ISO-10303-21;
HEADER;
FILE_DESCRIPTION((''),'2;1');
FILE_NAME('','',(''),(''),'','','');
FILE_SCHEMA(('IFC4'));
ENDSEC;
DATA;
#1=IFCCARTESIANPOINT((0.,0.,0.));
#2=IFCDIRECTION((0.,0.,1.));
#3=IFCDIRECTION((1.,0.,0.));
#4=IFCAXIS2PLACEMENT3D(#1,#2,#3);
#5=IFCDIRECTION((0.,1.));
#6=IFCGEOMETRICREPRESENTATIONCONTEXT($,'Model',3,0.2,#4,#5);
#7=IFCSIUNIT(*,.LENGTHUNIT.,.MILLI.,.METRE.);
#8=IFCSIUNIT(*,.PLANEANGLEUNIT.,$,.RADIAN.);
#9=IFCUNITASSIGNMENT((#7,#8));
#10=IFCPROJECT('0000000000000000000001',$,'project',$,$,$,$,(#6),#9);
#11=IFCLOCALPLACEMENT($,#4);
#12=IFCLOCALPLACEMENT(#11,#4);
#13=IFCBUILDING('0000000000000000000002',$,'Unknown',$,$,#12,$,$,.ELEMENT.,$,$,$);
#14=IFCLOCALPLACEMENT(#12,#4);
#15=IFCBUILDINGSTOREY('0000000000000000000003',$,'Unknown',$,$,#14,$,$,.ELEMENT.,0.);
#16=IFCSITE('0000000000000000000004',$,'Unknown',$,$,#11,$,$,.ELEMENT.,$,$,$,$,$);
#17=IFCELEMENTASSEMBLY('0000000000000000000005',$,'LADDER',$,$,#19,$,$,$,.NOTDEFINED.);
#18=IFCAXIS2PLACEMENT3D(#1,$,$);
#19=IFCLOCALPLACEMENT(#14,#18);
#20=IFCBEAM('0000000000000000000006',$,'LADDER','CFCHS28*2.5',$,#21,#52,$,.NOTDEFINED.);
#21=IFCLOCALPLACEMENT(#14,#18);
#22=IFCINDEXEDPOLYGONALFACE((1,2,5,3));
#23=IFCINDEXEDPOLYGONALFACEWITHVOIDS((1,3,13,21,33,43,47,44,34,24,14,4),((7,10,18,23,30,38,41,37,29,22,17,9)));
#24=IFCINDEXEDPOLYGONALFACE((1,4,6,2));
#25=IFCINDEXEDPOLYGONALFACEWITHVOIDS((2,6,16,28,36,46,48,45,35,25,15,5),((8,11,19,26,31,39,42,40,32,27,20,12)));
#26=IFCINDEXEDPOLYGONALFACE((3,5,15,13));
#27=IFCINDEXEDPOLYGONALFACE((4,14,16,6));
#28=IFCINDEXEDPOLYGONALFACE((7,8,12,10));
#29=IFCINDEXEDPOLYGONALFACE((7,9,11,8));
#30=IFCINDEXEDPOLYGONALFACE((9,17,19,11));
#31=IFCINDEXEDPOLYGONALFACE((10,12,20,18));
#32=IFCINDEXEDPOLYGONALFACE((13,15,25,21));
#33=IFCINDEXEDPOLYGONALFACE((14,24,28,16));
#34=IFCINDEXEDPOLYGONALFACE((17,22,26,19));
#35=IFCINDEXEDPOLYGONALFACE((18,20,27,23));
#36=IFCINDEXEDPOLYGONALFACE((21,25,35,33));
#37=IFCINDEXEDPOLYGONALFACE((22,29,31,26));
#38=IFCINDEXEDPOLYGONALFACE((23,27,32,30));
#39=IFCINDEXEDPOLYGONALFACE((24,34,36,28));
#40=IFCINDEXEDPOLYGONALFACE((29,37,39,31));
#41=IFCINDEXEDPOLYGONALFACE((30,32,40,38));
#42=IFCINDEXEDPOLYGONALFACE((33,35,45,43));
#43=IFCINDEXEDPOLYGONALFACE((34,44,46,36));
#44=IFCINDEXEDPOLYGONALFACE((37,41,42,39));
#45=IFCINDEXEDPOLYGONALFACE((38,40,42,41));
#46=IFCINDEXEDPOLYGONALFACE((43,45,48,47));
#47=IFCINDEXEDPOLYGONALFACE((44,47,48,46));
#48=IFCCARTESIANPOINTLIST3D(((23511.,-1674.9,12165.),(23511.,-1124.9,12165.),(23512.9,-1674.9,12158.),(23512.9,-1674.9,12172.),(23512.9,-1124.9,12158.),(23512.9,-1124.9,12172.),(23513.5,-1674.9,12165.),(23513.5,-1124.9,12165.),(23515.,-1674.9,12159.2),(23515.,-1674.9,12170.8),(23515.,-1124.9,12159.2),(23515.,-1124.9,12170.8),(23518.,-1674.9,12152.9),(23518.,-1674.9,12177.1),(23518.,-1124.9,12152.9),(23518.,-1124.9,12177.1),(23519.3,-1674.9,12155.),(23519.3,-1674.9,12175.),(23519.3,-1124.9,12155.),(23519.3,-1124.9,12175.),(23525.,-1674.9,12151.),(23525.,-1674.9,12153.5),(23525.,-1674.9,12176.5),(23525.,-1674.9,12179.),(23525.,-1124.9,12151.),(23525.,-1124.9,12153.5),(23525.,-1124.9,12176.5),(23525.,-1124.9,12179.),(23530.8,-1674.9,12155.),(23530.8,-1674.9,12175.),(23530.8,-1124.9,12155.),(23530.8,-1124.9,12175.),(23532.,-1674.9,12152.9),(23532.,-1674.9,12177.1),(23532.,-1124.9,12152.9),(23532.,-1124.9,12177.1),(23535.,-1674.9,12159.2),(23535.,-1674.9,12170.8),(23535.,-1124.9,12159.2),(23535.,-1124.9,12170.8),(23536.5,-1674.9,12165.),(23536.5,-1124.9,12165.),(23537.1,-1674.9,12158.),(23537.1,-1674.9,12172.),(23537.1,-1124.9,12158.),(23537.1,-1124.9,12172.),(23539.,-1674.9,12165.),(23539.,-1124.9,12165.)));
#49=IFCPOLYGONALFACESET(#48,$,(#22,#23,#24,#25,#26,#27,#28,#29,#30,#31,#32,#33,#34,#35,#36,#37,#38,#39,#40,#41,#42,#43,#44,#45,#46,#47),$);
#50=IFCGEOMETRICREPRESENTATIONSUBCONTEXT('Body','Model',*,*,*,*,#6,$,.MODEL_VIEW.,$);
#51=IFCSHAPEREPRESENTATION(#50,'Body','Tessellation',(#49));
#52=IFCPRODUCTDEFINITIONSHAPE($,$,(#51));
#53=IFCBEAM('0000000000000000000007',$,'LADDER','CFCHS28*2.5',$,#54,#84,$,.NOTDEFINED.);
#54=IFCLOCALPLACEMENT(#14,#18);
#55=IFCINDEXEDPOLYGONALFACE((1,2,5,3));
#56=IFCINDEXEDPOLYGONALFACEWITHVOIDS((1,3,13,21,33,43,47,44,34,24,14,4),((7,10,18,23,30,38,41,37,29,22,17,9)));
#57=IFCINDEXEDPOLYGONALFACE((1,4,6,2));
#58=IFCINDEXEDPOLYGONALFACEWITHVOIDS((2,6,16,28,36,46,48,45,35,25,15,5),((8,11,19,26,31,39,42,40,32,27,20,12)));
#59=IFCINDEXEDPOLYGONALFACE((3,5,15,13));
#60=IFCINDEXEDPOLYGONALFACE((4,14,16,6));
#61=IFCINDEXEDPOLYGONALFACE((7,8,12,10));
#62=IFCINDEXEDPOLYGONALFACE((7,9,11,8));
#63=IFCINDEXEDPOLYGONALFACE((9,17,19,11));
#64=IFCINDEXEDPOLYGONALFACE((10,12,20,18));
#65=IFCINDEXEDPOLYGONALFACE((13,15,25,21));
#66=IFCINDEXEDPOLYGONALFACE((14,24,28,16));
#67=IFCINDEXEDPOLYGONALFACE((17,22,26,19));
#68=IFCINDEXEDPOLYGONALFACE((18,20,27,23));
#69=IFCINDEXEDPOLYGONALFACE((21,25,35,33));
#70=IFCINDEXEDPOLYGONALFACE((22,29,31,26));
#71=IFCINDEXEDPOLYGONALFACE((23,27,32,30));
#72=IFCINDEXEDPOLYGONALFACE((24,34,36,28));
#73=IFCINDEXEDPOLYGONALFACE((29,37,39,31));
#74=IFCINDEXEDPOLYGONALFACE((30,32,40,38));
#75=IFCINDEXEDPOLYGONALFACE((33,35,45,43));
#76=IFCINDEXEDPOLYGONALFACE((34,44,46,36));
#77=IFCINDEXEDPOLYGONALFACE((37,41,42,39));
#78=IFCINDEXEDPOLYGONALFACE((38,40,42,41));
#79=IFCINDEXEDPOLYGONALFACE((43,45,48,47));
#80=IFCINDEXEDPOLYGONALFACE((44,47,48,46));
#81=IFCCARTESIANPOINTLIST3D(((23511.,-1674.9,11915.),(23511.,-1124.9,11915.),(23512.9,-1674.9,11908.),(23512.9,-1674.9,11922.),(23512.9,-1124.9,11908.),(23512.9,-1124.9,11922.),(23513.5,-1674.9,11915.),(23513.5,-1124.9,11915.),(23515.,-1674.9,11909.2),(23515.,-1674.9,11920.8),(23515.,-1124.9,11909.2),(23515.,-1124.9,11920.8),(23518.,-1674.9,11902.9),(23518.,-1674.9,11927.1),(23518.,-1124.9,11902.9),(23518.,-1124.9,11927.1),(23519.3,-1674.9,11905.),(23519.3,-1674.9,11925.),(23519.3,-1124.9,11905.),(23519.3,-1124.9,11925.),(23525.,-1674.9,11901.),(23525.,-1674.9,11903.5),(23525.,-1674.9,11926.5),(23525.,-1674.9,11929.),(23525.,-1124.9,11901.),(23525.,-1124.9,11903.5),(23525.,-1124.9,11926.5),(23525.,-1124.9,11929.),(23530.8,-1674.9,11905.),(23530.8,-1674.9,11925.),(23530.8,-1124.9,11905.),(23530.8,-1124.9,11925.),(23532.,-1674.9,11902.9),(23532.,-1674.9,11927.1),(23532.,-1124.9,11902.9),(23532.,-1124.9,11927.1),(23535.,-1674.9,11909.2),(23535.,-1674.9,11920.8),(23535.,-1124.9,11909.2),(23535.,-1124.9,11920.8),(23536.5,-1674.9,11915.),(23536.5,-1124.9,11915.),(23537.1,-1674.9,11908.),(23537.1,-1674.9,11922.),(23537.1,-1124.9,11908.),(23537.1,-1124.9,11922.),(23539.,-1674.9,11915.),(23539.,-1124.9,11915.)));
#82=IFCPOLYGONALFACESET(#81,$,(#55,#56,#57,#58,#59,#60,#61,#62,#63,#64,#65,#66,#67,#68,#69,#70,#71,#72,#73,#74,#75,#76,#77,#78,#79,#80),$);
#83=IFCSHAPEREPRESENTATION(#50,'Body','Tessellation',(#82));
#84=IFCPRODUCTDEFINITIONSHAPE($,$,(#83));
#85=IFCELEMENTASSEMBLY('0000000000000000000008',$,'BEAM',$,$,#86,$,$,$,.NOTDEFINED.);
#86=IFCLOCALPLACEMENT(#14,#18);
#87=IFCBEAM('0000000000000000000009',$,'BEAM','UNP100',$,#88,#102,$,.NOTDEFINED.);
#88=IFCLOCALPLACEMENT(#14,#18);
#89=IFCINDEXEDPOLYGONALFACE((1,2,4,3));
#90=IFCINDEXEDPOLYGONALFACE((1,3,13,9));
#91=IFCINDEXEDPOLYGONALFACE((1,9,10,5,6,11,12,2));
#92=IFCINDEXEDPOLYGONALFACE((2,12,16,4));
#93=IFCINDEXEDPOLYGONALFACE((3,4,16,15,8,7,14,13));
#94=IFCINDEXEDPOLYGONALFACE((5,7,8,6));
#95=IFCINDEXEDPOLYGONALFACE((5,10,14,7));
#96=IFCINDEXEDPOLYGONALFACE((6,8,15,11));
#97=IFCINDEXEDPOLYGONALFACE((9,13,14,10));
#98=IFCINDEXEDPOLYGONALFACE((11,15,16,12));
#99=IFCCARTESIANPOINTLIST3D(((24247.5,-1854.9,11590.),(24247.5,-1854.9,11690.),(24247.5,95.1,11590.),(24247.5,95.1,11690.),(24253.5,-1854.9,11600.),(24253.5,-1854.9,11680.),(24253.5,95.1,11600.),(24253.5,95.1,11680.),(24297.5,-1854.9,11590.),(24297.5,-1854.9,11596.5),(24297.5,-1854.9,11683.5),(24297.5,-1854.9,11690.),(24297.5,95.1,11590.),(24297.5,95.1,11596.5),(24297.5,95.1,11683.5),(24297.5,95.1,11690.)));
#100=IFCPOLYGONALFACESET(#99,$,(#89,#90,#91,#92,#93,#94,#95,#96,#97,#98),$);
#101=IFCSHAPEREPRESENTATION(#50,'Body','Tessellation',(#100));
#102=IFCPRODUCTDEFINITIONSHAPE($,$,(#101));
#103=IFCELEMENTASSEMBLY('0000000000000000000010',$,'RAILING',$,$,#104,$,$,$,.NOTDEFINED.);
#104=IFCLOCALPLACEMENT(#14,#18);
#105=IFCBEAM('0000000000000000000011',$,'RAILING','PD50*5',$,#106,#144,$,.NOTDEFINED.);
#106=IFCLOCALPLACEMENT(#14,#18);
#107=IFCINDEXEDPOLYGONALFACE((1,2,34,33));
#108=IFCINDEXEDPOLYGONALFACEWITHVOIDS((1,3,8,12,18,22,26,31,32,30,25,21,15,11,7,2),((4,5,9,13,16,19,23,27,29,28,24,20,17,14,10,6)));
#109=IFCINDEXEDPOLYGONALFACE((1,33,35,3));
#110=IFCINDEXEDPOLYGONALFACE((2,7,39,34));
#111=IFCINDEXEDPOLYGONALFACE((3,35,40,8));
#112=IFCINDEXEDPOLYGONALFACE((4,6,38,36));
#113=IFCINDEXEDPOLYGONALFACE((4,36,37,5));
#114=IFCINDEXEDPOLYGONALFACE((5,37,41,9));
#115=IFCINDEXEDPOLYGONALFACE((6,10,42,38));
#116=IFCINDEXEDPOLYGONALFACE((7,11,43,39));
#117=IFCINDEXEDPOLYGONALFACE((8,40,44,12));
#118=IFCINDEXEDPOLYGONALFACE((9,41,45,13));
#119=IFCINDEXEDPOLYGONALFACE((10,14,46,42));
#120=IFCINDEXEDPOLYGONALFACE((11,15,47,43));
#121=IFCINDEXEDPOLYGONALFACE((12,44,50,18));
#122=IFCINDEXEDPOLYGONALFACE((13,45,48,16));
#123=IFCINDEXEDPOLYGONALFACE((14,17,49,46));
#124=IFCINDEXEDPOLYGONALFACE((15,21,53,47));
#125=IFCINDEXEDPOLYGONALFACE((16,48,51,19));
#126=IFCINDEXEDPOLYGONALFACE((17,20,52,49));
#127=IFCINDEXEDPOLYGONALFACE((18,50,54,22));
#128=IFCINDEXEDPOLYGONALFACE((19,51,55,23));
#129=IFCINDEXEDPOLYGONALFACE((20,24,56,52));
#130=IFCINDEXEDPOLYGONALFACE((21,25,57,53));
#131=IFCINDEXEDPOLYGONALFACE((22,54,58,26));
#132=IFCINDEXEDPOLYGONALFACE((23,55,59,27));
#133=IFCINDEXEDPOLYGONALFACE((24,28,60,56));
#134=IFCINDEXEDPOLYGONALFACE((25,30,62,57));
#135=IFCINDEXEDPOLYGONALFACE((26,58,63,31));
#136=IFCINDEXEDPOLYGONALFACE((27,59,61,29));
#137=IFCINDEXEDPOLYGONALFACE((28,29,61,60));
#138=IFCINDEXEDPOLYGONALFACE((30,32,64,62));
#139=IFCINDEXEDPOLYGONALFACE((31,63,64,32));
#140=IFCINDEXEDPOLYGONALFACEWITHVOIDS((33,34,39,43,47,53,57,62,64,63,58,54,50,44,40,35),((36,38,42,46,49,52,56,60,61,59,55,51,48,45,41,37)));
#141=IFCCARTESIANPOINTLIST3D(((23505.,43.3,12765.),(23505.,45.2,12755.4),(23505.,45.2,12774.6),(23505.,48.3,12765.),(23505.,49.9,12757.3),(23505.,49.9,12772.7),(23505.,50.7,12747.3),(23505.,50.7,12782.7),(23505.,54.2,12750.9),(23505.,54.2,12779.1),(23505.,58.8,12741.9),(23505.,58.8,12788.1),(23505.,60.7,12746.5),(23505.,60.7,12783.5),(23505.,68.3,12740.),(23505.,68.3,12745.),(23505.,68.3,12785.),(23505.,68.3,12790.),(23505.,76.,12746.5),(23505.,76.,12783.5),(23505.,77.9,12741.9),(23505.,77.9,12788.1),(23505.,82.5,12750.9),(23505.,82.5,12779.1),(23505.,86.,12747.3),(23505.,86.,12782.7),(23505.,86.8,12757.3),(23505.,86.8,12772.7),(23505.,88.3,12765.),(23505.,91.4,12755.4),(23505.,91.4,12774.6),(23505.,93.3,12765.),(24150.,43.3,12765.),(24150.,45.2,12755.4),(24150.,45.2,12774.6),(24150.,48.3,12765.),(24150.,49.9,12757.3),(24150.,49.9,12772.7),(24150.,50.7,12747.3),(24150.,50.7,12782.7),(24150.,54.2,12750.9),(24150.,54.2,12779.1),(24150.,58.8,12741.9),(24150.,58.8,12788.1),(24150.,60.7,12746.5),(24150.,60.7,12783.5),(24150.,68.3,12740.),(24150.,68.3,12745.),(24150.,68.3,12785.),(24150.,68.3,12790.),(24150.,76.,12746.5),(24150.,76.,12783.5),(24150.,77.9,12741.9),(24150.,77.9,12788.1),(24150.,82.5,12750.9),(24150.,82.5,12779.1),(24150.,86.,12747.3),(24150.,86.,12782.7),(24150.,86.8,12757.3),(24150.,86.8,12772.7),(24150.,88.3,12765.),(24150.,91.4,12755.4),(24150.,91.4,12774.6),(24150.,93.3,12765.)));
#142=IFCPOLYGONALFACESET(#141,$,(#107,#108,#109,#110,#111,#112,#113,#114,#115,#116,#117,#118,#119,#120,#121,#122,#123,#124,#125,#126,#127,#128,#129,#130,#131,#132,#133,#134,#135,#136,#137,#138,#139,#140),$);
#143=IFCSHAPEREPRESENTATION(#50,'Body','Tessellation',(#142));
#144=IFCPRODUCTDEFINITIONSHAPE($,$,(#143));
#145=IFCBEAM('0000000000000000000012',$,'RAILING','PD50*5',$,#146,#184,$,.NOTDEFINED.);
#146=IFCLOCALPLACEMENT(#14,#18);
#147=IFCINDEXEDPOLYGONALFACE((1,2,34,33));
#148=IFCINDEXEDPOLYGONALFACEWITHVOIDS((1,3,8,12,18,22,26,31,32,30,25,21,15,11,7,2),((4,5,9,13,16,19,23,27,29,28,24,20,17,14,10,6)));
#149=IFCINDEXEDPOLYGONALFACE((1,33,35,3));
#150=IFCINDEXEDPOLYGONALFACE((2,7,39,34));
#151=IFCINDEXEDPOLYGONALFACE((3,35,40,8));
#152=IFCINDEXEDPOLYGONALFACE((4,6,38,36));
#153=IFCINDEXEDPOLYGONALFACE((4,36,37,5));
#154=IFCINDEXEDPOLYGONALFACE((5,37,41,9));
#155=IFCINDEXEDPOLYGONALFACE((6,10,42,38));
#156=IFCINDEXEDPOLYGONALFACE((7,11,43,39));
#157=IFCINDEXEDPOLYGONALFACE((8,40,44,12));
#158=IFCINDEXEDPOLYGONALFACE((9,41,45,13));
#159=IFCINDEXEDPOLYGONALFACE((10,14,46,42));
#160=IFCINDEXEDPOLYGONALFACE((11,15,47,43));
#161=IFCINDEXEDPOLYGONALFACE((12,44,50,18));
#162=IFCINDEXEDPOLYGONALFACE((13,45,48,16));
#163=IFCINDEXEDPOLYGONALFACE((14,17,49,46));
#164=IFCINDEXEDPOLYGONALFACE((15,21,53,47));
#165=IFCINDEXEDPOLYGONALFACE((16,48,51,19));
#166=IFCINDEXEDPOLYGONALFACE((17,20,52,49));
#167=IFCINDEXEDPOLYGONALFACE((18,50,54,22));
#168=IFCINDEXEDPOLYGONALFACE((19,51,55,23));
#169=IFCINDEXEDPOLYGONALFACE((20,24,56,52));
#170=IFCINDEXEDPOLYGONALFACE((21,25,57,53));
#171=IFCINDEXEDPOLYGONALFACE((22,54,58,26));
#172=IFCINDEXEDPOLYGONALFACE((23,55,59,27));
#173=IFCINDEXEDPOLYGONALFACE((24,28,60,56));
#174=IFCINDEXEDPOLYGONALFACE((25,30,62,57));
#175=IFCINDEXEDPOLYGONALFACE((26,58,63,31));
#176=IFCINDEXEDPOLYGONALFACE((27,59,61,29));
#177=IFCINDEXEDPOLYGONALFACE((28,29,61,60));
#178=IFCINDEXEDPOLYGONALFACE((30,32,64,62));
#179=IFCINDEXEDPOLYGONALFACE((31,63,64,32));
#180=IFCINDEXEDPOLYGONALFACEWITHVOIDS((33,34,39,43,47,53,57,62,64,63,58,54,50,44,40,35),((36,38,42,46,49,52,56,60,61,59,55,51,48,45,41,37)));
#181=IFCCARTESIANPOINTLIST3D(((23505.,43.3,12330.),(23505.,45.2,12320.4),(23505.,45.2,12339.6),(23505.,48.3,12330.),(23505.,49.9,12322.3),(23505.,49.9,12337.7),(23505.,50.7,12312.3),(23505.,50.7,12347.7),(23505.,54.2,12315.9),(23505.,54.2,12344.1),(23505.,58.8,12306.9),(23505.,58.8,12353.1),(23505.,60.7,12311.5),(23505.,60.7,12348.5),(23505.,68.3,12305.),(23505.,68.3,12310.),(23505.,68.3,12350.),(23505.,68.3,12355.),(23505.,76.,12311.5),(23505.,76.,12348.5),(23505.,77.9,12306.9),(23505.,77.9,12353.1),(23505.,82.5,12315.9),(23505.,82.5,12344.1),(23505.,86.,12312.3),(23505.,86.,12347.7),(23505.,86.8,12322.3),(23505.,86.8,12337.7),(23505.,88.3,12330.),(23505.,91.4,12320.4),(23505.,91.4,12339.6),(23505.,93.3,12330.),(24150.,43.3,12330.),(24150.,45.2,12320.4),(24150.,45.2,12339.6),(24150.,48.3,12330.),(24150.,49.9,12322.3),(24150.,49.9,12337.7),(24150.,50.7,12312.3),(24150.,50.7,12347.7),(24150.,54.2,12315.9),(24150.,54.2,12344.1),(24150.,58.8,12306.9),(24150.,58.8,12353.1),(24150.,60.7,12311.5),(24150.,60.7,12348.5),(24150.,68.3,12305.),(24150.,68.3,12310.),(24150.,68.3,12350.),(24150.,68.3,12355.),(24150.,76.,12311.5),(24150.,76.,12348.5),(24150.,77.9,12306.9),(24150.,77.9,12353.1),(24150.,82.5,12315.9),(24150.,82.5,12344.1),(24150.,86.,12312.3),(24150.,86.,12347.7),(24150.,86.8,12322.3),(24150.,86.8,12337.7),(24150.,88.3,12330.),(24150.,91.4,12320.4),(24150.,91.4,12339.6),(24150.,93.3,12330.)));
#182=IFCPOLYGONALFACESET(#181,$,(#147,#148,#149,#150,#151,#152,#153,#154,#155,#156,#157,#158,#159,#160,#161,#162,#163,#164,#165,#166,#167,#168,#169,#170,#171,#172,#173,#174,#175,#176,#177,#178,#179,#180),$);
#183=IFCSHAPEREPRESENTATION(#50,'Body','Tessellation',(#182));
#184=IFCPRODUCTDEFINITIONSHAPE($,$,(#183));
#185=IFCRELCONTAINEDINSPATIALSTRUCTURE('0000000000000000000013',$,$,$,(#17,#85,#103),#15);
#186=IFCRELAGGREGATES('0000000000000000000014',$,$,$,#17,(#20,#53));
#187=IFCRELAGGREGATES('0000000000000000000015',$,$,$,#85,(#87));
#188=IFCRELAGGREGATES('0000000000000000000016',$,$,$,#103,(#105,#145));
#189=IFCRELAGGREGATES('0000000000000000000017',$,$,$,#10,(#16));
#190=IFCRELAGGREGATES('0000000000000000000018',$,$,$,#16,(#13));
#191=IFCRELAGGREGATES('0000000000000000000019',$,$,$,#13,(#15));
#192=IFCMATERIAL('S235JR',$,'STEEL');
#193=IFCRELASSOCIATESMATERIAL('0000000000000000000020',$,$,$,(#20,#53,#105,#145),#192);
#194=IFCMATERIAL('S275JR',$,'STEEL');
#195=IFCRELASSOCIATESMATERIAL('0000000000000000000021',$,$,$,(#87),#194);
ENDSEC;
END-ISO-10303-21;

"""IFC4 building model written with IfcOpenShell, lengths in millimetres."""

from ifc_helpers import new_model, si_unit, direction, frame, origin_with_axes, place, context, subcontext, project, spatial, line, indexed_curve, outline, extrude, material, element, aggregate, save


model = new_model("IFC4")

# Units and contexts
model_context = context("Model", 3, precision=0.2, world=origin_with_axes(), true_north=direction((0.0, 1.0)))
body_context = subcontext(model_context, "Body", "Model", "MODEL_VIEW")
ifc_project = project(units=[si_unit("LENGTHUNIT", "METRE", prefix="MILLI"), si_unit("PLANEANGLEUNIT", "RADIAN")], contexts=[model_context])

# Site, building, storey
site_placement = place(None, origin_with_axes())
site = spatial("IfcSite", under=ifc_project, at=site_placement, Name="Unknown", CompositionType="ELEMENT")
building_placement = place(site_placement, origin_with_axes())
building = spatial("IfcBuilding", under=site, at=building_placement, Name="Unknown", CompositionType="ELEMENT")
storey_placement = place(building_placement, origin_with_axes())
storey = spatial("IfcBuildingStorey", under=building, at=storey_placement, Name="Unknown", CompositionType="ELEMENT", Elevation=0.0)

# Element assembly, beams
assembly_1_placement = place(storey_placement, frame((23525.0, -1699.9, 5175.0), z_axis=(0.0, 1.0, 0.0), x_axis=(0.0, 0.0, 1.0)))
assembly_1 = element("IfcElementAssembly", 1, at=assembly_1_placement, inside=storey, Name="LADDER", PredefinedType="NOTDEFINED")
ifc_material_1 = material(Name="S235JR", Category="STEEL")
ifc_material_2 = material(Name="S275JR", Category="STEEL")
beam_1_placement = place(assembly_1_placement, frame((6990.0, 0.0, 25.0), z_axis=(0.0, -1.0, 0.0), x_axis=(0.0, 0.0, 1.0)))
beam_1 = element("IfcBeam", 2, at=beam_1_placement, material=ifc_material_1, Name="LADDER", Description="CFCHS28*2.5", PredefinedType="NOTDEFINED", context=body_context, shape_type="SolidModel", body=[
    extrude(outline(indexed_curve([(14.0, 0.0), (12.1, 7.0), (7.0, 12.1), (0.0, 14.0), (-7.0, 12.1), (-12.1, 7.0), (-14.0, 0.0), (-12.1, -7.0), (-7.0, -12.1), (0.0, -14.0), (7.0, -12.1), (12.1, -7.0)], segments=[line(1, 2, 3, 4, 5, 6, 7, 8, 9, 10, 11, 12, 1)]), holes=[indexed_curve([(11.5, 0.0), (10.0, -5.8), (5.8, -10.0), (0.0, -11.5), (-5.8, -10.0), (-10.0, -5.8), (-11.5, 0.0), (-10.0, 5.8), (-5.8, 10.0), (0.0, 11.5), (5.8, 10.0), (10.0, 5.8)], segments=[line(1, 2, 3, 4, 5, 6, 7, 8, 9, 10, 11, 12, 1)])]), frame((0.0, 0.0, 0.0), z_axis=(-1.0, 0.0, 0.0), x_axis=(0.0, 0.0, 1.0)), (0.0, 0.0, -1.0), 550.0),
])
beam_2_placement = place(assembly_1_placement, frame((6740.0, 0.0, 25.0), z_axis=(0.0, -1.0, 0.0), x_axis=(0.0, 0.0, 1.0)))
beam_2 = element("IfcBeam", 3, at=beam_2_placement, material=ifc_material_1, Name="LADDER", Description="CFCHS28*2.5", PredefinedType="NOTDEFINED", context=body_context, shape_type="SolidModel", body=[
    extrude(outline(indexed_curve([(14.0, 0.0), (12.1, 7.0), (7.0, 12.1), (0.0, 14.0), (-7.0, 12.1), (-12.1, 7.0), (-14.0, 0.0), (-12.1, -7.0), (-7.0, -12.1), (0.0, -14.0), (7.0, -12.1), (12.1, -7.0)], segments=[line(1, 2, 3, 4, 5, 6, 7, 8, 9, 10, 11, 12, 1)]), holes=[indexed_curve([(11.5, 0.0), (10.0, -5.8), (5.8, -10.0), (0.0, -11.5), (-5.8, -10.0), (-10.0, -5.8), (-11.5, 0.0), (-10.0, 5.8), (-5.8, 10.0), (0.0, 11.5), (5.8, 10.0), (10.0, 5.8)], segments=[line(1, 2, 3, 4, 5, 6, 7, 8, 9, 10, 11, 12, 1)])]), frame((0.0, 0.0, 0.0), z_axis=(-1.0, 0.0, 0.0), x_axis=(0.0, 0.0, 1.0)), (0.0, 0.0, -1.0), 550.0),
])

# Element assembly, beam
assembly_2_placement = place(storey_placement, frame((24272.5, 95.1, 11640.0), z_axis=(1.0, 0.0, 0.0), x_axis=(0.0, -1.0, 0.0)))
assembly_2 = element("IfcElementAssembly", 4, at=assembly_2_placement, inside=storey, Name="BEAM", PredefinedType="NOTDEFINED")
beam_3_placement = place(assembly_2_placement, origin_with_axes())
beam_3 = element("IfcBeam", 5, at=beam_3_placement, material=ifc_material_2, Name="BEAM", Description="UNP100", PredefinedType="NOTDEFINED", context=body_context, shape_type="SolidModel", body=[
    extrude(outline(indexed_curve([(-25.0, -50.0), (25.0, -50.0), (25.0, -43.5), (-19.0, -40.0), (-19.0, 40.0), (25.0, 43.5), (25.0, 50.0), (-25.0, 50.0)], segments=[line(1, 2, 3, 4, 5, 6, 7, 8, 1)])), frame((0.0, 0.0, 0.0), z_axis=(-1.0, 0.0, 0.0), x_axis=(0.0, 0.0, 1.0)), (0.0, 0.0, -1.0), 1950.0),
])

# Element assembly, beams
assembly_3_placement = place(storey_placement, frame((24272.5, -1304.9, 12765.0), z_axis=(-1.0, 0.0, 0.0), x_axis=(0.0, 1.0, 0.0)))
assembly_3 = element("IfcElementAssembly", 6, at=assembly_3_placement, inside=storey, Name="RAILING", PredefinedType="NOTDEFINED")
beam_4_placement = place(assembly_3_placement, frame((1373.3, 0.0, 122.5), z_axis=(-1.0, 0.0, 0.0), x_axis=(0.0, 0.0, 1.0)))
beam_4 = element("IfcBeam", 7, at=beam_4_placement, material=ifc_material_1, Name="RAILING", Description="PD50*5", PredefinedType="NOTDEFINED", context=body_context, shape_type="SolidModel", body=[
    extrude(outline(indexed_curve([(25.0, 0.0), (23.1, 9.6), (17.7, 17.7), (9.6, 23.1), (0.0, 25.0), (-9.6, 23.1), (-17.7, 17.7), (-23.1, 9.6), (-25.0, 0.0), (-23.1, -9.6), (-17.7, -17.7), (-9.6, -23.1), (0.0, -25.0), (9.6, -23.1), (17.7, -17.7), (23.1, -9.6)], segments=[line(1, 2, 3, 4, 5, 6, 7, 8, 9, 10, 11, 12, 13, 14, 15, 16, 1)]), holes=[indexed_curve([(20.0, 0.0), (18.5, -7.7), (14.1, -14.1), (7.7, -18.5), (0.0, -20.0), (-7.7, -18.5), (-14.1, -14.1), (-18.5, -7.7), (-20.0, 0.0), (-18.5, 7.7), (-14.1, 14.1), (-7.7, 18.5), (0.0, 20.0), (7.7, 18.5), (14.1, 14.1), (18.5, 7.7)], segments=[line(1, 2, 3, 4, 5, 6, 7, 8, 9, 10, 11, 12, 13, 14, 15, 16, 1)])]), frame((0.0, 0.0, 0.0), z_axis=(-1.0, 0.0, 0.0), x_axis=(0.0, 0.0, 1.0)), (0.0, 0.0, -1.0), 645.0),
])
beam_5_placement = place(assembly_3_placement, frame((1373.3, 435.0, 122.5), z_axis=(0.0, -1.0, 0.0), x_axis=(0.0, 0.0, 1.0)))
beam_5 = element("IfcBeam", 8, at=beam_5_placement, material=ifc_material_1, Name="RAILING", Description="PD50*5", PredefinedType="NOTDEFINED", context=body_context, shape_type="SolidModel", body=[
    extrude(outline(indexed_curve([(25.0, 0.0), (23.1, 9.6), (17.7, 17.7), (9.6, 23.1), (0.0, 25.0), (-9.6, 23.1), (-17.7, 17.7), (-23.1, 9.6), (-25.0, 0.0), (-23.1, -9.6), (-17.7, -17.7), (-9.6, -23.1), (0.0, -25.0), (9.6, -23.1), (17.7, -17.7), (23.1, -9.6)], segments=[line(1, 2, 3, 4, 5, 6, 7, 8, 9, 10, 11, 12, 13, 14, 15, 16, 1)]), holes=[indexed_curve([(20.0, 0.0), (18.5, -7.7), (14.1, -14.1), (7.7, -18.5), (0.0, -20.0), (-7.7, -18.5), (-14.1, -14.1), (-18.5, -7.7), (-20.0, 0.0), (-18.5, 7.7), (-14.1, 14.1), (-7.7, 18.5), (0.0, 20.0), (7.7, 18.5), (14.1, 14.1), (18.5, 7.7)], segments=[line(1, 2, 3, 4, 5, 6, 7, 8, 9, 10, 11, 12, 13, 14, 15, 16, 1)])]), frame((0.0, 0.0, 0.0), z_axis=(-1.0, 0.0, 0.0), x_axis=(0.0, 0.0, 1.0)), (0.0, 0.0, -1.0), 645.0),
])

aggregate(assembly_1, [beam_1, beam_2])
aggregate(assembly_2, [beam_3])
aggregate(assembly_3, [beam_4, beam_5])

save(model, "model.ifc")
